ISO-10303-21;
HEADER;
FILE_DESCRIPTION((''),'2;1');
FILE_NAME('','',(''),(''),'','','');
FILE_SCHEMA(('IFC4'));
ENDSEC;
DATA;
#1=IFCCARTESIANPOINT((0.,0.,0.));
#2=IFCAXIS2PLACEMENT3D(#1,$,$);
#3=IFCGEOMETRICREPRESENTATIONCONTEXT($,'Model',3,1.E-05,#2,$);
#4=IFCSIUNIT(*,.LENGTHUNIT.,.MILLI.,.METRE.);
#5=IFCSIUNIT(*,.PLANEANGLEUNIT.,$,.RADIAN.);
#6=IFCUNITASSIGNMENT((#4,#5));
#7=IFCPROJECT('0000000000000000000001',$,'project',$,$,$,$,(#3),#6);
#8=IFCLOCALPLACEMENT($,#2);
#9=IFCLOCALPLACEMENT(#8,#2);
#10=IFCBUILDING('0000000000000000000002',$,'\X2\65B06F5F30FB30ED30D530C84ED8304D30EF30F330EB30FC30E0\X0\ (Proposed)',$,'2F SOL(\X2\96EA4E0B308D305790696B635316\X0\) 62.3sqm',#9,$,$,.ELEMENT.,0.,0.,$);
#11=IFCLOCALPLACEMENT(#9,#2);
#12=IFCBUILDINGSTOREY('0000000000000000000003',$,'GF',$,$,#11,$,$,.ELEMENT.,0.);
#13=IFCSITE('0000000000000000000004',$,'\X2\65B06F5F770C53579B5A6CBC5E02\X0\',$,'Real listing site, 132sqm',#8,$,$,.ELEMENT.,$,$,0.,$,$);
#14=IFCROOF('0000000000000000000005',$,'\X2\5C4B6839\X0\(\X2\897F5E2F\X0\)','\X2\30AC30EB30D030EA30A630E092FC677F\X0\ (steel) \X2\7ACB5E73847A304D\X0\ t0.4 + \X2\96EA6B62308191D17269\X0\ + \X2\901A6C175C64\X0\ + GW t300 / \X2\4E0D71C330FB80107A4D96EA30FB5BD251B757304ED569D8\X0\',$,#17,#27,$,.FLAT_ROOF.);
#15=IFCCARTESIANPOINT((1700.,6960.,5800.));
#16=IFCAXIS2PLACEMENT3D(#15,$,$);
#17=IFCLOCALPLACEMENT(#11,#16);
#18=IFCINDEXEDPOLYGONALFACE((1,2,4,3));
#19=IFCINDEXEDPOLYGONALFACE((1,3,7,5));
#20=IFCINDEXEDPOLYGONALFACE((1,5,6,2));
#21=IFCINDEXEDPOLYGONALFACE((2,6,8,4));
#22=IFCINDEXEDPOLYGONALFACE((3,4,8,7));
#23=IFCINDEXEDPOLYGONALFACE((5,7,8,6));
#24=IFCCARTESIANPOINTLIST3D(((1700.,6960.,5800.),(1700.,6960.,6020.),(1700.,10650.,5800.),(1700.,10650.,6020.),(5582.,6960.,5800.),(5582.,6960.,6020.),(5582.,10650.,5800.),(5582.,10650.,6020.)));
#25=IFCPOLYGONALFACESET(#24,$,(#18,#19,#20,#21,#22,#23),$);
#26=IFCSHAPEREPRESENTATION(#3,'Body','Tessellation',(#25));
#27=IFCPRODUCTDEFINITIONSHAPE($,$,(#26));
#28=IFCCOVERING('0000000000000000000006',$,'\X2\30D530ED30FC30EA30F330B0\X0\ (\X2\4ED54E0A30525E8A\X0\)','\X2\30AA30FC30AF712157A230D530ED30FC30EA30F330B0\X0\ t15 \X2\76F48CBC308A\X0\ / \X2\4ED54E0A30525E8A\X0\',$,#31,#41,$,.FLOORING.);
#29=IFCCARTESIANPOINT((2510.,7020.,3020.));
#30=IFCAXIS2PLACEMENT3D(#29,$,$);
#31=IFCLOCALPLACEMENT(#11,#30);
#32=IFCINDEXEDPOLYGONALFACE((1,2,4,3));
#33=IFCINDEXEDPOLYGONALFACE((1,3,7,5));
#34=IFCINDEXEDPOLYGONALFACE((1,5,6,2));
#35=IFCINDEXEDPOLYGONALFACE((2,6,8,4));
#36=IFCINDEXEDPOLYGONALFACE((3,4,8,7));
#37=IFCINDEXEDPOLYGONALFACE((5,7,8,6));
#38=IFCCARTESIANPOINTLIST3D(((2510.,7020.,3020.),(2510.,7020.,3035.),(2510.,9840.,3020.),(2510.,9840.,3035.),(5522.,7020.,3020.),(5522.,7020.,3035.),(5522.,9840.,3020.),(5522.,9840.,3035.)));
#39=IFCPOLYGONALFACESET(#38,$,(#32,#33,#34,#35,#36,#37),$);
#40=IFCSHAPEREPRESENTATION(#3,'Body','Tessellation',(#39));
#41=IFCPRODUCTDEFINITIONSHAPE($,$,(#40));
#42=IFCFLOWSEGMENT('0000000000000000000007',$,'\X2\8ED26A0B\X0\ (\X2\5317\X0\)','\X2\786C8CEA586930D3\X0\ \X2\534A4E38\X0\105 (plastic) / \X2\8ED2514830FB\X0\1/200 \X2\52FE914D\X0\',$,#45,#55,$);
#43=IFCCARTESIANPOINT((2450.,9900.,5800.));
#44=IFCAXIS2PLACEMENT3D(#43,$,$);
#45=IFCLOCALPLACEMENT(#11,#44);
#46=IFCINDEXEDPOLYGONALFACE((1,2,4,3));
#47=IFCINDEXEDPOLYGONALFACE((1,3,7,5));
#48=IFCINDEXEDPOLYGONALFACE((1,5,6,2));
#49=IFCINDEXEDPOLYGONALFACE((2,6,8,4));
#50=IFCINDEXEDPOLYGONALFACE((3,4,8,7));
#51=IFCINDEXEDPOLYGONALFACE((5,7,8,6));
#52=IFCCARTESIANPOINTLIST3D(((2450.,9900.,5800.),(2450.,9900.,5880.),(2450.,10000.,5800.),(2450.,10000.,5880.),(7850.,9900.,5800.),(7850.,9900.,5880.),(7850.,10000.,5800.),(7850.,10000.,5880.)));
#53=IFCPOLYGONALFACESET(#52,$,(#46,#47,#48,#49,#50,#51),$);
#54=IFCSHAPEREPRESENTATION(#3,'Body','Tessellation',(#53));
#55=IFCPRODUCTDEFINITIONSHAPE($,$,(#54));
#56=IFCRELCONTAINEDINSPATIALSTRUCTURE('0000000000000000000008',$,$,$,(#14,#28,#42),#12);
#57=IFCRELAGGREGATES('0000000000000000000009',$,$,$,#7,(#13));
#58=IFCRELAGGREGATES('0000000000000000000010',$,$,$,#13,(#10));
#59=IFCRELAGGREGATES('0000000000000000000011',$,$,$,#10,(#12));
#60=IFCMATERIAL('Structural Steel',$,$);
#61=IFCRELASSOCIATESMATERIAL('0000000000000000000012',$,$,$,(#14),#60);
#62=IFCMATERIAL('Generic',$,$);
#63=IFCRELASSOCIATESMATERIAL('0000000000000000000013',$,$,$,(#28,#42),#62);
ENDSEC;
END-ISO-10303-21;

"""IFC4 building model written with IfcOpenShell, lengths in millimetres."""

from ifc_helpers import new_model, si_unit, frame, frame_2d, origin, place, context, project, spatial, rectangle, extrude, material, element, save


model = new_model("IFC4")

# Units and contexts
model_context = context("Model", 3, precision=1e-05, world=origin())
ifc_project = project(units=[si_unit("LENGTHUNIT", "METRE", prefix="MILLI"), si_unit("PLANEANGLEUNIT", "RADIAN")], contexts=[model_context])

# Site, building, storey
site_placement = place(None, origin())
site = spatial("IfcSite", under=ifc_project, at=site_placement, Name="新潟県南魚沼市", ObjectType="Real listing site, 132sqm", CompositionType="ELEMENT", RefElevation=0.0)
building_placement = place(site_placement, origin())
building = spatial("IfcBuilding", under=site, at=building_placement, Name="新潟・ロフト付きワンルーム (Proposed)", ObjectType="2F SOL(雪下ろし適正化) 62.3sqm", CompositionType="ELEMENT", ElevationOfRefHeight=0.0, ElevationOfTerrain=0.0)
storey_placement = place(building_placement, origin())
storey = spatial("IfcBuildingStorey", under=building, at=storey_placement, Name="GF", CompositionType="ELEMENT", Elevation=0.0)

# Roof
ifc_material_1 = material(Name="Structural Steel")
for number, where, name in (
    (1, (1700.0, 6960.0, 5800.0), "屋根(西帯)"),
):
    element("IfcRoof", number, at=place(storey_placement, frame(where)), inside=storey, material=ifc_material_1, Name=name, Description="ガルバリウム鋼板 (steel) 立平葺き t0.4 + 雪止め金物 + 通気層 + GW t300 / 不燃・耐積雪・寒冷地仕様", PredefinedType="FLAT_ROOF", context=model_context, shape_type="SweptSolid", body=[
        extrude(rectangle(XDim=3882.0, YDim=3690.0, at=frame_2d((1941.0, 1845.0))), frame((1700.0, 6960.0, 5800.0)), (0.0, 0.0, 1.0), 220.0),
    ])

# Covering
ifc_material_2 = material(Name="Generic")
covering_placement = place(storey_placement, frame((2510.0, 7020.0, 3020.0)))
element("IfcCovering", 2, at=covering_placement, inside=storey, material=ifc_material_2, Name="フローリング (仕上げ床)", Description="オーク無垢フローリング t15 直貼り / 仕上げ床", PredefinedType="FLOORING", context=model_context, shape_type="SweptSolid", body=[
    extrude(rectangle(XDim=3012.0, YDim=2820.0, at=frame_2d((1506.0, 1410.0))), frame((2510.0, 7020.0, 3020.0)), (0.0, 0.0, 1.0), 15.0),
])

# Flow segment
flow_segment_placement = place(storey_placement, frame((2450.0, 9900.0, 5800.0)))
element("IfcFlowSegment", 3, at=flow_segment_placement, inside=storey, material=ifc_material_2, Name="軒樋 (北)", Description="硬質塩ビ 半丸105 (plastic) / 軒先・1/200 勾配", context=model_context, shape_type="SweptSolid", body=[
    extrude(rectangle(XDim=5400.0, YDim=100.0, at=frame_2d((2700.0, 50.0))), frame((2450.0, 9900.0, 5800.0)), (0.0, 0.0, 1.0), 80.0),
])

save(model, "model.ifc")
